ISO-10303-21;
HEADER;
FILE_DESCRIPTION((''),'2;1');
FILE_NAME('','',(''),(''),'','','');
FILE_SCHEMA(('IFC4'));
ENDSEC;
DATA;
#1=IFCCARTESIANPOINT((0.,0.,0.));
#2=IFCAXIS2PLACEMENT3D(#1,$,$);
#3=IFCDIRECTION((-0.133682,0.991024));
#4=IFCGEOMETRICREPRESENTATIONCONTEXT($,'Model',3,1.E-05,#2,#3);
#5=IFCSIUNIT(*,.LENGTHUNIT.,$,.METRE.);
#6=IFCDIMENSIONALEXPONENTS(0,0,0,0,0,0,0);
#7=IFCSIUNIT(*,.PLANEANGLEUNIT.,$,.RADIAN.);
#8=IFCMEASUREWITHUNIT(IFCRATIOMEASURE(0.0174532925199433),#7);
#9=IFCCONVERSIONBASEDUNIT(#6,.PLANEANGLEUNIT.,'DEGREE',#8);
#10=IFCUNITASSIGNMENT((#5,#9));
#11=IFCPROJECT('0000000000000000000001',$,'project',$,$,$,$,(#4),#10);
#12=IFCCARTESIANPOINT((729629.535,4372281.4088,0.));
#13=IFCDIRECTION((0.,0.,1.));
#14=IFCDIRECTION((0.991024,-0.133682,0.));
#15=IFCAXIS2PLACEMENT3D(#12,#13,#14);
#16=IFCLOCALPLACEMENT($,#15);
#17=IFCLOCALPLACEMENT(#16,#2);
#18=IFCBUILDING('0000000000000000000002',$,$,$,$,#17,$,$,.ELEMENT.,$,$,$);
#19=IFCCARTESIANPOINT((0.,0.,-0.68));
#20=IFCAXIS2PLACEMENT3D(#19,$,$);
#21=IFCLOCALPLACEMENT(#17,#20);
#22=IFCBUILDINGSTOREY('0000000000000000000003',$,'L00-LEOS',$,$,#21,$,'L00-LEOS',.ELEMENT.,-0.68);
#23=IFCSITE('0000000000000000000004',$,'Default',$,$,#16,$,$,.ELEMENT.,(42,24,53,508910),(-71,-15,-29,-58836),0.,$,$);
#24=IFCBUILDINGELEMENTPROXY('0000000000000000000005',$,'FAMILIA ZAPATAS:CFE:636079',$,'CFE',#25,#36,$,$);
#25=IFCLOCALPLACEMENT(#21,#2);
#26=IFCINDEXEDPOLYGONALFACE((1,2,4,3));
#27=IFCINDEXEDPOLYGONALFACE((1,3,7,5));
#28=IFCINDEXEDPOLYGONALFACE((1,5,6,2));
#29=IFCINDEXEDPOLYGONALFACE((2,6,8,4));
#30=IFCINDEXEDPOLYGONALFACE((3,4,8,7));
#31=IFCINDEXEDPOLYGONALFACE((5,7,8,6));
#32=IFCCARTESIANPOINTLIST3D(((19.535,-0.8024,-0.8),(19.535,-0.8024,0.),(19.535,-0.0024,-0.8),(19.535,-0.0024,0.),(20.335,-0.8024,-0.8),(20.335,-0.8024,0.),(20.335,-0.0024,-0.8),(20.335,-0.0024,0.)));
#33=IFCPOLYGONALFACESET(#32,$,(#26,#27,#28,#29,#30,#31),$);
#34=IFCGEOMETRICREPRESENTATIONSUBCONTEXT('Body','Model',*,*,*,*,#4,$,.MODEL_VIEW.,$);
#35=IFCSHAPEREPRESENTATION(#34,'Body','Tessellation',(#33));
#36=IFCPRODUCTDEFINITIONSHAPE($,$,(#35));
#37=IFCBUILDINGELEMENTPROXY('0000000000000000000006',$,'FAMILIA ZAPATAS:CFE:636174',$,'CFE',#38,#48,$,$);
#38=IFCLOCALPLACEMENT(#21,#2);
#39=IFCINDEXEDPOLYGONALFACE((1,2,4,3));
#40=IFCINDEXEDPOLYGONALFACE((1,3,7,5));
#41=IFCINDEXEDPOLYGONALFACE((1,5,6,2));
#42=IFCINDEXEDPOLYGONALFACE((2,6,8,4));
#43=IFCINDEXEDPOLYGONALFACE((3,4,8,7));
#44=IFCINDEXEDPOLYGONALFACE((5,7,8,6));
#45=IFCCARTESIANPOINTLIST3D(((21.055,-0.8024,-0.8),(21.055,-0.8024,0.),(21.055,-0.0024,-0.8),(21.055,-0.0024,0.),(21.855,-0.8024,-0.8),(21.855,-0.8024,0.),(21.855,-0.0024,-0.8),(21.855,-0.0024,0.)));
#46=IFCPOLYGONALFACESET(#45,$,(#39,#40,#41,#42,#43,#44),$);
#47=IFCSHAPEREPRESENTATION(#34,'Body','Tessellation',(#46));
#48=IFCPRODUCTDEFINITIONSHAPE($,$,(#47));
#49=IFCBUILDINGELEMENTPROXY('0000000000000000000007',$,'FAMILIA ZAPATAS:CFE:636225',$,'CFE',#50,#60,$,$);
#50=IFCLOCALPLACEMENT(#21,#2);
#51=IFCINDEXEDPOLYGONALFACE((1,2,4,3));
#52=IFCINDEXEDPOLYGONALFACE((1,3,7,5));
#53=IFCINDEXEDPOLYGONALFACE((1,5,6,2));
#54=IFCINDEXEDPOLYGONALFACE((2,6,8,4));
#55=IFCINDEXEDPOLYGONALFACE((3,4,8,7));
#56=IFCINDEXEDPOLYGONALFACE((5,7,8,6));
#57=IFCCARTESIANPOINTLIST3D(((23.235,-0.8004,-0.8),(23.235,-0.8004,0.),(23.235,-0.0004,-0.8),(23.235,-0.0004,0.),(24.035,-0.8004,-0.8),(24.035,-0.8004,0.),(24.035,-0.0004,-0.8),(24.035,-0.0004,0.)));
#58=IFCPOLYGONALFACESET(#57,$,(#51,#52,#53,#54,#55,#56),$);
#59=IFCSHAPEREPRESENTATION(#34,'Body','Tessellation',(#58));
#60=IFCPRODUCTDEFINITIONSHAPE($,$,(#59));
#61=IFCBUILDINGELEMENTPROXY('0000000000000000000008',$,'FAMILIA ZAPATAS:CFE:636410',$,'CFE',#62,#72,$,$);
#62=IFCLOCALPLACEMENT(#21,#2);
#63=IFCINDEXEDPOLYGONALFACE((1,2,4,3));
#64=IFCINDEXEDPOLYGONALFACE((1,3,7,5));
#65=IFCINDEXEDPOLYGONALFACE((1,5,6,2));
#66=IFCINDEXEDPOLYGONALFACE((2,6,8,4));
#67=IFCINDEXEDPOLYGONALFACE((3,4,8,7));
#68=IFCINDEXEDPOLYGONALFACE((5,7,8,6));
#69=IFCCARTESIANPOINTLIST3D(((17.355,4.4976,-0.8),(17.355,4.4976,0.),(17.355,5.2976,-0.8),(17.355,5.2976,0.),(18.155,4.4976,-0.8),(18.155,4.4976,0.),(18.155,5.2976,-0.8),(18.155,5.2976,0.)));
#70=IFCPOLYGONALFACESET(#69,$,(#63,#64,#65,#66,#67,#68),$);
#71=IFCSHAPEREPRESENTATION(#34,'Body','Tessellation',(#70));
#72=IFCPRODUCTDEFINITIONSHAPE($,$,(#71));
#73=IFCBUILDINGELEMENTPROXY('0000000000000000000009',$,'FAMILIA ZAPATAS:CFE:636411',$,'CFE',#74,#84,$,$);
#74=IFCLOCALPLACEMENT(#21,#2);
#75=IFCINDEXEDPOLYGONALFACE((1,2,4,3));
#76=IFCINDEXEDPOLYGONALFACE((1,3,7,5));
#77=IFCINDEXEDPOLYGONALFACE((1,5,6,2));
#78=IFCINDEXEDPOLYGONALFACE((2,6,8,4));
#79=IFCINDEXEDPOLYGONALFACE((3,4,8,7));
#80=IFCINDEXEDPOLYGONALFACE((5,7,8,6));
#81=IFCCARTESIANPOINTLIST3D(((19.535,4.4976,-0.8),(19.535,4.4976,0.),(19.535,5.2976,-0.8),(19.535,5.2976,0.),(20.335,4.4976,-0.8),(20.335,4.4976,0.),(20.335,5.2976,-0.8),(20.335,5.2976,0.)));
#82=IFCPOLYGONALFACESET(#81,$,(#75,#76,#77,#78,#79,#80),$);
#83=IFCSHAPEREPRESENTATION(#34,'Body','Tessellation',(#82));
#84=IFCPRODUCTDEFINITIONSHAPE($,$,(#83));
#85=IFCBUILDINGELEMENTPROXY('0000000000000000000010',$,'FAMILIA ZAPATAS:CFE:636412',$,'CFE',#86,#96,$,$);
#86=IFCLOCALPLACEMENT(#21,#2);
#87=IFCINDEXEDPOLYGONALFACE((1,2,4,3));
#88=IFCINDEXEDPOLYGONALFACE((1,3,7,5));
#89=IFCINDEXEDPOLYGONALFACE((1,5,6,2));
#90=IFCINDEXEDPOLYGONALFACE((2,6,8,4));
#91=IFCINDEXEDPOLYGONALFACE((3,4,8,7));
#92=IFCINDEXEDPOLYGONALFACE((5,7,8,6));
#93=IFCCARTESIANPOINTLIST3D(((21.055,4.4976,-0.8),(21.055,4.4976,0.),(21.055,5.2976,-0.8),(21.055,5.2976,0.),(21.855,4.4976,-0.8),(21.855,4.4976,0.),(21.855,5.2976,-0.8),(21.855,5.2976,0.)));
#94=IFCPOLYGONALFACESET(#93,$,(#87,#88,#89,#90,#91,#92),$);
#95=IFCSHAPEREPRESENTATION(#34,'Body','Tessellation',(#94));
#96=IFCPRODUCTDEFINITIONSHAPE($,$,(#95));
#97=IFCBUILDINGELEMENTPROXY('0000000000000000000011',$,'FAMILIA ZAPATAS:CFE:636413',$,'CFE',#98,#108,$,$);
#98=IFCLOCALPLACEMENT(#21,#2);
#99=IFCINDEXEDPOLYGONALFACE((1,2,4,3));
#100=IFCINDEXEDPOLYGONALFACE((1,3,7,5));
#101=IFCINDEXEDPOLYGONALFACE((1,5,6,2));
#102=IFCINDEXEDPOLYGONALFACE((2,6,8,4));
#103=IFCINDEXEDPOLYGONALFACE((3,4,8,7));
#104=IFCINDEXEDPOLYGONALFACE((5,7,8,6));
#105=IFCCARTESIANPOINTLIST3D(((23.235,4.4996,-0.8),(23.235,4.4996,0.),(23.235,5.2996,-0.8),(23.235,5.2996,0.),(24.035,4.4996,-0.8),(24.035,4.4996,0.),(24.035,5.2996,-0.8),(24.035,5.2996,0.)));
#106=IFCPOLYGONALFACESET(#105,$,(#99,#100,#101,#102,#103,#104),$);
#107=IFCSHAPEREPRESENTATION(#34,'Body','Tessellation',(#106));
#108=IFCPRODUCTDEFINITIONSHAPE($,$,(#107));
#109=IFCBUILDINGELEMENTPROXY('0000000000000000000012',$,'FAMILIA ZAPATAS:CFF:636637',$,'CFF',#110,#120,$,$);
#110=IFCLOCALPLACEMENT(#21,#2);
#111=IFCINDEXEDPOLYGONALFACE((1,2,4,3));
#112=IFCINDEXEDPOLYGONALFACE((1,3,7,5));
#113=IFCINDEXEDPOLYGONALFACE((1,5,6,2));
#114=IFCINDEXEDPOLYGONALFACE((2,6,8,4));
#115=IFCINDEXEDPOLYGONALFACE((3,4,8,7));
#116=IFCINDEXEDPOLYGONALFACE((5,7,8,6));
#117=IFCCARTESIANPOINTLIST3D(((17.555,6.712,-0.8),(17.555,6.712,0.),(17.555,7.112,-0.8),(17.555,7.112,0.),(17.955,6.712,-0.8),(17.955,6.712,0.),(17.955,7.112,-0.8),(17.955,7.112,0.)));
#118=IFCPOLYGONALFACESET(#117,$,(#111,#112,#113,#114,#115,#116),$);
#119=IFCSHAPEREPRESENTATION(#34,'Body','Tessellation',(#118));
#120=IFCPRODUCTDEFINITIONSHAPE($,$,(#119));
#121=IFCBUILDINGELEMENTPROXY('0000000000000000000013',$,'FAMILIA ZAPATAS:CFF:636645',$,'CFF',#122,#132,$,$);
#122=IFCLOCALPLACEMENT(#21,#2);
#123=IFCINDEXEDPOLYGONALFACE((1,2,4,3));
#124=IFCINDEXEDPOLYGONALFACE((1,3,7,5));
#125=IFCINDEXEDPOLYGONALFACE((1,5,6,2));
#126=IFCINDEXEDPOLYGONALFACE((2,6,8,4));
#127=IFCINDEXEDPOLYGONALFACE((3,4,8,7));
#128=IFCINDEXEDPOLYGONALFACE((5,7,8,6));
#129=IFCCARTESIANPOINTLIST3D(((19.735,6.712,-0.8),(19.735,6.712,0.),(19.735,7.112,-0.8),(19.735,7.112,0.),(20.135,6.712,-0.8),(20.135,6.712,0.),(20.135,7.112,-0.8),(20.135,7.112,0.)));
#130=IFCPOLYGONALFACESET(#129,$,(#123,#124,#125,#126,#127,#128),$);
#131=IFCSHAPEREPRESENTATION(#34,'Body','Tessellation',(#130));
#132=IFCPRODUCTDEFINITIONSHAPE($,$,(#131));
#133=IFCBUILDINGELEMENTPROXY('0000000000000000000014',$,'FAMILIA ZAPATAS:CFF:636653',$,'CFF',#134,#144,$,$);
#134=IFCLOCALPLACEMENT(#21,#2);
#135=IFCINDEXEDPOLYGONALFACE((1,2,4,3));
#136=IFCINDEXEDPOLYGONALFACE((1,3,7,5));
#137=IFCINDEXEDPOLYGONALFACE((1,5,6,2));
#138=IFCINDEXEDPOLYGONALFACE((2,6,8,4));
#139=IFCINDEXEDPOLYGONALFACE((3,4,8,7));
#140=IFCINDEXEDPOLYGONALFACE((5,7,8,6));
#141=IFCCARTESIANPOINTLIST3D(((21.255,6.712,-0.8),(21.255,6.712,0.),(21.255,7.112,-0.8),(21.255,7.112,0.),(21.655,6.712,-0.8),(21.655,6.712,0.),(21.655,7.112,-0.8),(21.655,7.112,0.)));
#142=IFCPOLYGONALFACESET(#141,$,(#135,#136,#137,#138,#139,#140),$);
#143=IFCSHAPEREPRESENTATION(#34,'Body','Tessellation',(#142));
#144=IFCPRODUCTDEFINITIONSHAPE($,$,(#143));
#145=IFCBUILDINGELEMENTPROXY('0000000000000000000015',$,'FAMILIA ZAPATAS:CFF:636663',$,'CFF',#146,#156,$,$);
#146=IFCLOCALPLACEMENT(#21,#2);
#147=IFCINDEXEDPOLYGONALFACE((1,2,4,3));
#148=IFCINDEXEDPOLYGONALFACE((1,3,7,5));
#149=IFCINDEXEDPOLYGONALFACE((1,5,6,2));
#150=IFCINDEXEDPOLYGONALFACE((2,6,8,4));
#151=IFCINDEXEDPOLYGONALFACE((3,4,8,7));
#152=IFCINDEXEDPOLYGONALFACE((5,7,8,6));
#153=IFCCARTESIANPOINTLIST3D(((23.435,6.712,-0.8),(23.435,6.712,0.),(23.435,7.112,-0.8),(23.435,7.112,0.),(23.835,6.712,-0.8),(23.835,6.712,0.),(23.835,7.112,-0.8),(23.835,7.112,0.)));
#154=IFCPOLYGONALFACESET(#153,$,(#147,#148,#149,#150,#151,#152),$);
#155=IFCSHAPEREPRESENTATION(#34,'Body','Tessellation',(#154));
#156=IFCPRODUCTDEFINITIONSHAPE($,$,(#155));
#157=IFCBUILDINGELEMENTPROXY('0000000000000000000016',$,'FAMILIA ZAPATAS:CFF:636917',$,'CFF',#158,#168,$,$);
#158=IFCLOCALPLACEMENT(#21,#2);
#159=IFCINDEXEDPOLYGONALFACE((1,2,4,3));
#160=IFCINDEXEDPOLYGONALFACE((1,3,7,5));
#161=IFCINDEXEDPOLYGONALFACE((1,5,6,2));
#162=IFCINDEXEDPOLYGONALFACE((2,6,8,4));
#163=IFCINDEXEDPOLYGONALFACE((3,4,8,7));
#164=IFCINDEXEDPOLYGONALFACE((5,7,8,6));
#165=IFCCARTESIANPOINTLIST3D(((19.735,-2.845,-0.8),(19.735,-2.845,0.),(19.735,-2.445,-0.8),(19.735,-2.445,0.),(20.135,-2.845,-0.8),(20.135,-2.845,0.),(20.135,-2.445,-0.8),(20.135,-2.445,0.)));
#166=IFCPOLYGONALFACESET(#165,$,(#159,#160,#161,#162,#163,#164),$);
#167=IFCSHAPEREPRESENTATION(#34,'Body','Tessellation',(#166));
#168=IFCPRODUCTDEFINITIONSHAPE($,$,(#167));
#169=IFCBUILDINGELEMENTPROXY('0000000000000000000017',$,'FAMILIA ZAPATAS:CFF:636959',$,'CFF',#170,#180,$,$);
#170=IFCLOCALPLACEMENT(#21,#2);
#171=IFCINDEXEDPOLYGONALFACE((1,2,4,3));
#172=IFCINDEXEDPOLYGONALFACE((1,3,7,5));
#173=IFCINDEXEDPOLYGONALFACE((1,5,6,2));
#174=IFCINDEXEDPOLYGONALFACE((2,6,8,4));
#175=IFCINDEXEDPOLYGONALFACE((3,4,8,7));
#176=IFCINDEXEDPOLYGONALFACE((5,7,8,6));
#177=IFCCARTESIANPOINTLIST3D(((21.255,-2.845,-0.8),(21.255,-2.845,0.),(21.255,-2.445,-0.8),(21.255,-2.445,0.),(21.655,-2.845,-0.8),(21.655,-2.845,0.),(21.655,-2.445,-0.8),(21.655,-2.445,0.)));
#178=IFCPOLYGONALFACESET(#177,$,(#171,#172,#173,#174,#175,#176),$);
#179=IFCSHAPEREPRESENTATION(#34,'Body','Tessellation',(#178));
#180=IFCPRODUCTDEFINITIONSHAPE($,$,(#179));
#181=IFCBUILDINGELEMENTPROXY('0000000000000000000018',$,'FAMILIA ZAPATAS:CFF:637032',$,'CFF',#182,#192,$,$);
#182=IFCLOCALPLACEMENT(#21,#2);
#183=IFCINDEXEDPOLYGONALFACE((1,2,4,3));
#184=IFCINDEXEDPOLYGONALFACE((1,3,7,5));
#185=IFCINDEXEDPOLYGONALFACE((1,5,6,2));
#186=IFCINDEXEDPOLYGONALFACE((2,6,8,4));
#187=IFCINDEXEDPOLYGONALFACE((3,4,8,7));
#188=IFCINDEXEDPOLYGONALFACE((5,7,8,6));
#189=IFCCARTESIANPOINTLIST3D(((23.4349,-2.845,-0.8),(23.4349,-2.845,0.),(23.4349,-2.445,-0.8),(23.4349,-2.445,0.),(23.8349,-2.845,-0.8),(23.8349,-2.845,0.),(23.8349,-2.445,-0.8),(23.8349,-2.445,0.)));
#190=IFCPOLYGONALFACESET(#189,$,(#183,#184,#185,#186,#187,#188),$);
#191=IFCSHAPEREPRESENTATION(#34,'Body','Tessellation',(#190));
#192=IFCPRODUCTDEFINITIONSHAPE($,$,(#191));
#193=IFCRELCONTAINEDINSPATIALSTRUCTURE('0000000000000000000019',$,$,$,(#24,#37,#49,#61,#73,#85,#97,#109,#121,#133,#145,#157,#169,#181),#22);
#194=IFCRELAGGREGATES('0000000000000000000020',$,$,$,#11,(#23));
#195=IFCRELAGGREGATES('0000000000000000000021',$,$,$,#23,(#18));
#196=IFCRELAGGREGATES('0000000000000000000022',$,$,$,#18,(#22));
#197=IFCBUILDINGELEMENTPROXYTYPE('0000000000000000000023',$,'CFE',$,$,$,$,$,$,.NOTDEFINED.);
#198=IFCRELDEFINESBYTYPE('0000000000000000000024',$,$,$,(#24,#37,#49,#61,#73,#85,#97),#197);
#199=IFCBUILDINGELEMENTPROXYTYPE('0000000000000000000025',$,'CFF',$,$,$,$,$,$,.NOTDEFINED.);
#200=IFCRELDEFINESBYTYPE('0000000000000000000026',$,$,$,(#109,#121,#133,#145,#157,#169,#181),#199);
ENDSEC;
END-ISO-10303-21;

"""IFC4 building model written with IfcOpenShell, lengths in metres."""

from ifc_helpers import new_model, entity, si_unit, converted_unit, direction, frame, origin, origin_2d_with_axis, place, context, subcontext, project, spatial, rectangle, extrude, source, transform, mapped, type_object, type_shapes, element, save


model = new_model("IFC4")

# Units and contexts
model_context = context("Model", 3, precision=1e-05, world=origin(), true_north=direction((-0.133682, 0.991024)))
body_context = subcontext(model_context, "Body", "Model", "MODEL_VIEW")
ifc_project = project(units=[si_unit("LENGTHUNIT", "METRE"), converted_unit("PLANEANGLEUNIT", "DEGREE", entity("IfcRatioMeasure", 0.0174532925199433), si_unit("PLANEANGLEUNIT", "RADIAN"), dimensions=[0, 0, 0, 0, 0, 0, 0])], contexts=[model_context])

# Site, building, storey
site_placement = place(None, frame((729629.535, 4372281.4088, 0.0), z_axis=(0.0, 0.0, 1.0), x_axis=(0.991024, -0.133682, 0.0)))
site = spatial("IfcSite", under=ifc_project, at=site_placement, Name="Default", CompositionType="ELEMENT", RefLatitude=(42, 24, 53, 508910), RefLongitude=(-71, -15, -29, -58836), RefElevation=0.0)
building_placement = place(site_placement, origin())
building = spatial("IfcBuilding", under=site, at=building_placement, CompositionType="ELEMENT")
storey_placement = place(building_placement, frame((0.0, 0.0, -0.68)))
storey = spatial("IfcBuildingStorey", under=building, at=storey_placement, Name="L00-LEOS", LongName="L00-LEOS", CompositionType="ELEMENT", Elevation=-0.68)

# Building element proxies
building_element_proxy_type_1 = type_object("IfcBuildingElementProxyType", Name="CFE")
shared_shape_1 = source(origin(), body_context, "Body", "SweptSolid", [
    extrude(rectangle(XDim=0.8, YDim=0.8, at=origin_2d_with_axis()), frame((0.0, 0.0, 0.0), z_axis=(0.0, 0.0, 1.0), x_axis=(0.0, -1.0, 0.0)), (0.0, 0.0, 1.0), 0.8),
])
type_shapes(building_element_proxy_type_1, [shared_shape_1])
for number, where, name in (
    (1, (19.935, -0.4024, -0.8), "FAMILIA ZAPATAS:CFE:636079"),
    (2, (21.455, -0.4024, -0.8), "FAMILIA ZAPATAS:CFE:636174"),
    (3, (23.635, -0.4004, -0.8), "FAMILIA ZAPATAS:CFE:636225"),
    (4, (17.755, 4.8976, -0.8), "FAMILIA ZAPATAS:CFE:636410"),
    (5, (19.935, 4.8976, -0.8), "FAMILIA ZAPATAS:CFE:636411"),
    (6, (21.455, 4.8976, -0.8), "FAMILIA ZAPATAS:CFE:636412"),
    (7, (23.635, 4.8996, -0.8), "FAMILIA ZAPATAS:CFE:636413"),
):
    element("IfcBuildingElementProxy", number, at=place(storey_placement, frame(where)), inside=storey, type_object=building_element_proxy_type_1, Name=name, ObjectType="CFE", context=body_context, shape_type="MappedRepresentation", body=[
        mapped(shared_shape_1, transform((0.0, 0.0, 0.0), scale=1.0)),
    ])
building_element_proxy_type_2 = type_object("IfcBuildingElementProxyType", Name="CFF")
shared_shape_2 = source(origin(), body_context, "Body", "SweptSolid", [
    extrude(rectangle(XDim=0.4, YDim=0.4, at=origin_2d_with_axis()), frame((0.0, 0.0, 0.0), z_axis=(0.0, 0.0, 1.0), x_axis=(0.0, -1.0, 0.0)), (0.0, 0.0, 1.0), 0.8),
])
type_shapes(building_element_proxy_type_2, [shared_shape_2])
for number, where, name in (
    (8, (17.755, 6.912, -0.8), "FAMILIA ZAPATAS:CFF:636637"),
    (9, (19.935, 6.912, -0.8), "FAMILIA ZAPATAS:CFF:636645"),
    (10, (21.455, 6.912, -0.8), "FAMILIA ZAPATAS:CFF:636653"),
    (11, (23.635, 6.912, -0.8), "FAMILIA ZAPATAS:CFF:636663"),
    (12, (19.935, -2.645, -0.8), "FAMILIA ZAPATAS:CFF:636917"),
    (13, (21.455, -2.645, -0.8), "FAMILIA ZAPATAS:CFF:636959"),
    (14, (23.6349, -2.645, -0.8), "FAMILIA ZAPATAS:CFF:637032"),
):
    element("IfcBuildingElementProxy", number, at=place(storey_placement, frame(where)), inside=storey, type_object=building_element_proxy_type_2, Name=name, ObjectType="CFF", context=body_context, shape_type="MappedRepresentation", body=[
        mapped(shared_shape_2, transform((0.0, 0.0, 0.0), scale=1.0)),
    ])

save(model, "model.ifc")
